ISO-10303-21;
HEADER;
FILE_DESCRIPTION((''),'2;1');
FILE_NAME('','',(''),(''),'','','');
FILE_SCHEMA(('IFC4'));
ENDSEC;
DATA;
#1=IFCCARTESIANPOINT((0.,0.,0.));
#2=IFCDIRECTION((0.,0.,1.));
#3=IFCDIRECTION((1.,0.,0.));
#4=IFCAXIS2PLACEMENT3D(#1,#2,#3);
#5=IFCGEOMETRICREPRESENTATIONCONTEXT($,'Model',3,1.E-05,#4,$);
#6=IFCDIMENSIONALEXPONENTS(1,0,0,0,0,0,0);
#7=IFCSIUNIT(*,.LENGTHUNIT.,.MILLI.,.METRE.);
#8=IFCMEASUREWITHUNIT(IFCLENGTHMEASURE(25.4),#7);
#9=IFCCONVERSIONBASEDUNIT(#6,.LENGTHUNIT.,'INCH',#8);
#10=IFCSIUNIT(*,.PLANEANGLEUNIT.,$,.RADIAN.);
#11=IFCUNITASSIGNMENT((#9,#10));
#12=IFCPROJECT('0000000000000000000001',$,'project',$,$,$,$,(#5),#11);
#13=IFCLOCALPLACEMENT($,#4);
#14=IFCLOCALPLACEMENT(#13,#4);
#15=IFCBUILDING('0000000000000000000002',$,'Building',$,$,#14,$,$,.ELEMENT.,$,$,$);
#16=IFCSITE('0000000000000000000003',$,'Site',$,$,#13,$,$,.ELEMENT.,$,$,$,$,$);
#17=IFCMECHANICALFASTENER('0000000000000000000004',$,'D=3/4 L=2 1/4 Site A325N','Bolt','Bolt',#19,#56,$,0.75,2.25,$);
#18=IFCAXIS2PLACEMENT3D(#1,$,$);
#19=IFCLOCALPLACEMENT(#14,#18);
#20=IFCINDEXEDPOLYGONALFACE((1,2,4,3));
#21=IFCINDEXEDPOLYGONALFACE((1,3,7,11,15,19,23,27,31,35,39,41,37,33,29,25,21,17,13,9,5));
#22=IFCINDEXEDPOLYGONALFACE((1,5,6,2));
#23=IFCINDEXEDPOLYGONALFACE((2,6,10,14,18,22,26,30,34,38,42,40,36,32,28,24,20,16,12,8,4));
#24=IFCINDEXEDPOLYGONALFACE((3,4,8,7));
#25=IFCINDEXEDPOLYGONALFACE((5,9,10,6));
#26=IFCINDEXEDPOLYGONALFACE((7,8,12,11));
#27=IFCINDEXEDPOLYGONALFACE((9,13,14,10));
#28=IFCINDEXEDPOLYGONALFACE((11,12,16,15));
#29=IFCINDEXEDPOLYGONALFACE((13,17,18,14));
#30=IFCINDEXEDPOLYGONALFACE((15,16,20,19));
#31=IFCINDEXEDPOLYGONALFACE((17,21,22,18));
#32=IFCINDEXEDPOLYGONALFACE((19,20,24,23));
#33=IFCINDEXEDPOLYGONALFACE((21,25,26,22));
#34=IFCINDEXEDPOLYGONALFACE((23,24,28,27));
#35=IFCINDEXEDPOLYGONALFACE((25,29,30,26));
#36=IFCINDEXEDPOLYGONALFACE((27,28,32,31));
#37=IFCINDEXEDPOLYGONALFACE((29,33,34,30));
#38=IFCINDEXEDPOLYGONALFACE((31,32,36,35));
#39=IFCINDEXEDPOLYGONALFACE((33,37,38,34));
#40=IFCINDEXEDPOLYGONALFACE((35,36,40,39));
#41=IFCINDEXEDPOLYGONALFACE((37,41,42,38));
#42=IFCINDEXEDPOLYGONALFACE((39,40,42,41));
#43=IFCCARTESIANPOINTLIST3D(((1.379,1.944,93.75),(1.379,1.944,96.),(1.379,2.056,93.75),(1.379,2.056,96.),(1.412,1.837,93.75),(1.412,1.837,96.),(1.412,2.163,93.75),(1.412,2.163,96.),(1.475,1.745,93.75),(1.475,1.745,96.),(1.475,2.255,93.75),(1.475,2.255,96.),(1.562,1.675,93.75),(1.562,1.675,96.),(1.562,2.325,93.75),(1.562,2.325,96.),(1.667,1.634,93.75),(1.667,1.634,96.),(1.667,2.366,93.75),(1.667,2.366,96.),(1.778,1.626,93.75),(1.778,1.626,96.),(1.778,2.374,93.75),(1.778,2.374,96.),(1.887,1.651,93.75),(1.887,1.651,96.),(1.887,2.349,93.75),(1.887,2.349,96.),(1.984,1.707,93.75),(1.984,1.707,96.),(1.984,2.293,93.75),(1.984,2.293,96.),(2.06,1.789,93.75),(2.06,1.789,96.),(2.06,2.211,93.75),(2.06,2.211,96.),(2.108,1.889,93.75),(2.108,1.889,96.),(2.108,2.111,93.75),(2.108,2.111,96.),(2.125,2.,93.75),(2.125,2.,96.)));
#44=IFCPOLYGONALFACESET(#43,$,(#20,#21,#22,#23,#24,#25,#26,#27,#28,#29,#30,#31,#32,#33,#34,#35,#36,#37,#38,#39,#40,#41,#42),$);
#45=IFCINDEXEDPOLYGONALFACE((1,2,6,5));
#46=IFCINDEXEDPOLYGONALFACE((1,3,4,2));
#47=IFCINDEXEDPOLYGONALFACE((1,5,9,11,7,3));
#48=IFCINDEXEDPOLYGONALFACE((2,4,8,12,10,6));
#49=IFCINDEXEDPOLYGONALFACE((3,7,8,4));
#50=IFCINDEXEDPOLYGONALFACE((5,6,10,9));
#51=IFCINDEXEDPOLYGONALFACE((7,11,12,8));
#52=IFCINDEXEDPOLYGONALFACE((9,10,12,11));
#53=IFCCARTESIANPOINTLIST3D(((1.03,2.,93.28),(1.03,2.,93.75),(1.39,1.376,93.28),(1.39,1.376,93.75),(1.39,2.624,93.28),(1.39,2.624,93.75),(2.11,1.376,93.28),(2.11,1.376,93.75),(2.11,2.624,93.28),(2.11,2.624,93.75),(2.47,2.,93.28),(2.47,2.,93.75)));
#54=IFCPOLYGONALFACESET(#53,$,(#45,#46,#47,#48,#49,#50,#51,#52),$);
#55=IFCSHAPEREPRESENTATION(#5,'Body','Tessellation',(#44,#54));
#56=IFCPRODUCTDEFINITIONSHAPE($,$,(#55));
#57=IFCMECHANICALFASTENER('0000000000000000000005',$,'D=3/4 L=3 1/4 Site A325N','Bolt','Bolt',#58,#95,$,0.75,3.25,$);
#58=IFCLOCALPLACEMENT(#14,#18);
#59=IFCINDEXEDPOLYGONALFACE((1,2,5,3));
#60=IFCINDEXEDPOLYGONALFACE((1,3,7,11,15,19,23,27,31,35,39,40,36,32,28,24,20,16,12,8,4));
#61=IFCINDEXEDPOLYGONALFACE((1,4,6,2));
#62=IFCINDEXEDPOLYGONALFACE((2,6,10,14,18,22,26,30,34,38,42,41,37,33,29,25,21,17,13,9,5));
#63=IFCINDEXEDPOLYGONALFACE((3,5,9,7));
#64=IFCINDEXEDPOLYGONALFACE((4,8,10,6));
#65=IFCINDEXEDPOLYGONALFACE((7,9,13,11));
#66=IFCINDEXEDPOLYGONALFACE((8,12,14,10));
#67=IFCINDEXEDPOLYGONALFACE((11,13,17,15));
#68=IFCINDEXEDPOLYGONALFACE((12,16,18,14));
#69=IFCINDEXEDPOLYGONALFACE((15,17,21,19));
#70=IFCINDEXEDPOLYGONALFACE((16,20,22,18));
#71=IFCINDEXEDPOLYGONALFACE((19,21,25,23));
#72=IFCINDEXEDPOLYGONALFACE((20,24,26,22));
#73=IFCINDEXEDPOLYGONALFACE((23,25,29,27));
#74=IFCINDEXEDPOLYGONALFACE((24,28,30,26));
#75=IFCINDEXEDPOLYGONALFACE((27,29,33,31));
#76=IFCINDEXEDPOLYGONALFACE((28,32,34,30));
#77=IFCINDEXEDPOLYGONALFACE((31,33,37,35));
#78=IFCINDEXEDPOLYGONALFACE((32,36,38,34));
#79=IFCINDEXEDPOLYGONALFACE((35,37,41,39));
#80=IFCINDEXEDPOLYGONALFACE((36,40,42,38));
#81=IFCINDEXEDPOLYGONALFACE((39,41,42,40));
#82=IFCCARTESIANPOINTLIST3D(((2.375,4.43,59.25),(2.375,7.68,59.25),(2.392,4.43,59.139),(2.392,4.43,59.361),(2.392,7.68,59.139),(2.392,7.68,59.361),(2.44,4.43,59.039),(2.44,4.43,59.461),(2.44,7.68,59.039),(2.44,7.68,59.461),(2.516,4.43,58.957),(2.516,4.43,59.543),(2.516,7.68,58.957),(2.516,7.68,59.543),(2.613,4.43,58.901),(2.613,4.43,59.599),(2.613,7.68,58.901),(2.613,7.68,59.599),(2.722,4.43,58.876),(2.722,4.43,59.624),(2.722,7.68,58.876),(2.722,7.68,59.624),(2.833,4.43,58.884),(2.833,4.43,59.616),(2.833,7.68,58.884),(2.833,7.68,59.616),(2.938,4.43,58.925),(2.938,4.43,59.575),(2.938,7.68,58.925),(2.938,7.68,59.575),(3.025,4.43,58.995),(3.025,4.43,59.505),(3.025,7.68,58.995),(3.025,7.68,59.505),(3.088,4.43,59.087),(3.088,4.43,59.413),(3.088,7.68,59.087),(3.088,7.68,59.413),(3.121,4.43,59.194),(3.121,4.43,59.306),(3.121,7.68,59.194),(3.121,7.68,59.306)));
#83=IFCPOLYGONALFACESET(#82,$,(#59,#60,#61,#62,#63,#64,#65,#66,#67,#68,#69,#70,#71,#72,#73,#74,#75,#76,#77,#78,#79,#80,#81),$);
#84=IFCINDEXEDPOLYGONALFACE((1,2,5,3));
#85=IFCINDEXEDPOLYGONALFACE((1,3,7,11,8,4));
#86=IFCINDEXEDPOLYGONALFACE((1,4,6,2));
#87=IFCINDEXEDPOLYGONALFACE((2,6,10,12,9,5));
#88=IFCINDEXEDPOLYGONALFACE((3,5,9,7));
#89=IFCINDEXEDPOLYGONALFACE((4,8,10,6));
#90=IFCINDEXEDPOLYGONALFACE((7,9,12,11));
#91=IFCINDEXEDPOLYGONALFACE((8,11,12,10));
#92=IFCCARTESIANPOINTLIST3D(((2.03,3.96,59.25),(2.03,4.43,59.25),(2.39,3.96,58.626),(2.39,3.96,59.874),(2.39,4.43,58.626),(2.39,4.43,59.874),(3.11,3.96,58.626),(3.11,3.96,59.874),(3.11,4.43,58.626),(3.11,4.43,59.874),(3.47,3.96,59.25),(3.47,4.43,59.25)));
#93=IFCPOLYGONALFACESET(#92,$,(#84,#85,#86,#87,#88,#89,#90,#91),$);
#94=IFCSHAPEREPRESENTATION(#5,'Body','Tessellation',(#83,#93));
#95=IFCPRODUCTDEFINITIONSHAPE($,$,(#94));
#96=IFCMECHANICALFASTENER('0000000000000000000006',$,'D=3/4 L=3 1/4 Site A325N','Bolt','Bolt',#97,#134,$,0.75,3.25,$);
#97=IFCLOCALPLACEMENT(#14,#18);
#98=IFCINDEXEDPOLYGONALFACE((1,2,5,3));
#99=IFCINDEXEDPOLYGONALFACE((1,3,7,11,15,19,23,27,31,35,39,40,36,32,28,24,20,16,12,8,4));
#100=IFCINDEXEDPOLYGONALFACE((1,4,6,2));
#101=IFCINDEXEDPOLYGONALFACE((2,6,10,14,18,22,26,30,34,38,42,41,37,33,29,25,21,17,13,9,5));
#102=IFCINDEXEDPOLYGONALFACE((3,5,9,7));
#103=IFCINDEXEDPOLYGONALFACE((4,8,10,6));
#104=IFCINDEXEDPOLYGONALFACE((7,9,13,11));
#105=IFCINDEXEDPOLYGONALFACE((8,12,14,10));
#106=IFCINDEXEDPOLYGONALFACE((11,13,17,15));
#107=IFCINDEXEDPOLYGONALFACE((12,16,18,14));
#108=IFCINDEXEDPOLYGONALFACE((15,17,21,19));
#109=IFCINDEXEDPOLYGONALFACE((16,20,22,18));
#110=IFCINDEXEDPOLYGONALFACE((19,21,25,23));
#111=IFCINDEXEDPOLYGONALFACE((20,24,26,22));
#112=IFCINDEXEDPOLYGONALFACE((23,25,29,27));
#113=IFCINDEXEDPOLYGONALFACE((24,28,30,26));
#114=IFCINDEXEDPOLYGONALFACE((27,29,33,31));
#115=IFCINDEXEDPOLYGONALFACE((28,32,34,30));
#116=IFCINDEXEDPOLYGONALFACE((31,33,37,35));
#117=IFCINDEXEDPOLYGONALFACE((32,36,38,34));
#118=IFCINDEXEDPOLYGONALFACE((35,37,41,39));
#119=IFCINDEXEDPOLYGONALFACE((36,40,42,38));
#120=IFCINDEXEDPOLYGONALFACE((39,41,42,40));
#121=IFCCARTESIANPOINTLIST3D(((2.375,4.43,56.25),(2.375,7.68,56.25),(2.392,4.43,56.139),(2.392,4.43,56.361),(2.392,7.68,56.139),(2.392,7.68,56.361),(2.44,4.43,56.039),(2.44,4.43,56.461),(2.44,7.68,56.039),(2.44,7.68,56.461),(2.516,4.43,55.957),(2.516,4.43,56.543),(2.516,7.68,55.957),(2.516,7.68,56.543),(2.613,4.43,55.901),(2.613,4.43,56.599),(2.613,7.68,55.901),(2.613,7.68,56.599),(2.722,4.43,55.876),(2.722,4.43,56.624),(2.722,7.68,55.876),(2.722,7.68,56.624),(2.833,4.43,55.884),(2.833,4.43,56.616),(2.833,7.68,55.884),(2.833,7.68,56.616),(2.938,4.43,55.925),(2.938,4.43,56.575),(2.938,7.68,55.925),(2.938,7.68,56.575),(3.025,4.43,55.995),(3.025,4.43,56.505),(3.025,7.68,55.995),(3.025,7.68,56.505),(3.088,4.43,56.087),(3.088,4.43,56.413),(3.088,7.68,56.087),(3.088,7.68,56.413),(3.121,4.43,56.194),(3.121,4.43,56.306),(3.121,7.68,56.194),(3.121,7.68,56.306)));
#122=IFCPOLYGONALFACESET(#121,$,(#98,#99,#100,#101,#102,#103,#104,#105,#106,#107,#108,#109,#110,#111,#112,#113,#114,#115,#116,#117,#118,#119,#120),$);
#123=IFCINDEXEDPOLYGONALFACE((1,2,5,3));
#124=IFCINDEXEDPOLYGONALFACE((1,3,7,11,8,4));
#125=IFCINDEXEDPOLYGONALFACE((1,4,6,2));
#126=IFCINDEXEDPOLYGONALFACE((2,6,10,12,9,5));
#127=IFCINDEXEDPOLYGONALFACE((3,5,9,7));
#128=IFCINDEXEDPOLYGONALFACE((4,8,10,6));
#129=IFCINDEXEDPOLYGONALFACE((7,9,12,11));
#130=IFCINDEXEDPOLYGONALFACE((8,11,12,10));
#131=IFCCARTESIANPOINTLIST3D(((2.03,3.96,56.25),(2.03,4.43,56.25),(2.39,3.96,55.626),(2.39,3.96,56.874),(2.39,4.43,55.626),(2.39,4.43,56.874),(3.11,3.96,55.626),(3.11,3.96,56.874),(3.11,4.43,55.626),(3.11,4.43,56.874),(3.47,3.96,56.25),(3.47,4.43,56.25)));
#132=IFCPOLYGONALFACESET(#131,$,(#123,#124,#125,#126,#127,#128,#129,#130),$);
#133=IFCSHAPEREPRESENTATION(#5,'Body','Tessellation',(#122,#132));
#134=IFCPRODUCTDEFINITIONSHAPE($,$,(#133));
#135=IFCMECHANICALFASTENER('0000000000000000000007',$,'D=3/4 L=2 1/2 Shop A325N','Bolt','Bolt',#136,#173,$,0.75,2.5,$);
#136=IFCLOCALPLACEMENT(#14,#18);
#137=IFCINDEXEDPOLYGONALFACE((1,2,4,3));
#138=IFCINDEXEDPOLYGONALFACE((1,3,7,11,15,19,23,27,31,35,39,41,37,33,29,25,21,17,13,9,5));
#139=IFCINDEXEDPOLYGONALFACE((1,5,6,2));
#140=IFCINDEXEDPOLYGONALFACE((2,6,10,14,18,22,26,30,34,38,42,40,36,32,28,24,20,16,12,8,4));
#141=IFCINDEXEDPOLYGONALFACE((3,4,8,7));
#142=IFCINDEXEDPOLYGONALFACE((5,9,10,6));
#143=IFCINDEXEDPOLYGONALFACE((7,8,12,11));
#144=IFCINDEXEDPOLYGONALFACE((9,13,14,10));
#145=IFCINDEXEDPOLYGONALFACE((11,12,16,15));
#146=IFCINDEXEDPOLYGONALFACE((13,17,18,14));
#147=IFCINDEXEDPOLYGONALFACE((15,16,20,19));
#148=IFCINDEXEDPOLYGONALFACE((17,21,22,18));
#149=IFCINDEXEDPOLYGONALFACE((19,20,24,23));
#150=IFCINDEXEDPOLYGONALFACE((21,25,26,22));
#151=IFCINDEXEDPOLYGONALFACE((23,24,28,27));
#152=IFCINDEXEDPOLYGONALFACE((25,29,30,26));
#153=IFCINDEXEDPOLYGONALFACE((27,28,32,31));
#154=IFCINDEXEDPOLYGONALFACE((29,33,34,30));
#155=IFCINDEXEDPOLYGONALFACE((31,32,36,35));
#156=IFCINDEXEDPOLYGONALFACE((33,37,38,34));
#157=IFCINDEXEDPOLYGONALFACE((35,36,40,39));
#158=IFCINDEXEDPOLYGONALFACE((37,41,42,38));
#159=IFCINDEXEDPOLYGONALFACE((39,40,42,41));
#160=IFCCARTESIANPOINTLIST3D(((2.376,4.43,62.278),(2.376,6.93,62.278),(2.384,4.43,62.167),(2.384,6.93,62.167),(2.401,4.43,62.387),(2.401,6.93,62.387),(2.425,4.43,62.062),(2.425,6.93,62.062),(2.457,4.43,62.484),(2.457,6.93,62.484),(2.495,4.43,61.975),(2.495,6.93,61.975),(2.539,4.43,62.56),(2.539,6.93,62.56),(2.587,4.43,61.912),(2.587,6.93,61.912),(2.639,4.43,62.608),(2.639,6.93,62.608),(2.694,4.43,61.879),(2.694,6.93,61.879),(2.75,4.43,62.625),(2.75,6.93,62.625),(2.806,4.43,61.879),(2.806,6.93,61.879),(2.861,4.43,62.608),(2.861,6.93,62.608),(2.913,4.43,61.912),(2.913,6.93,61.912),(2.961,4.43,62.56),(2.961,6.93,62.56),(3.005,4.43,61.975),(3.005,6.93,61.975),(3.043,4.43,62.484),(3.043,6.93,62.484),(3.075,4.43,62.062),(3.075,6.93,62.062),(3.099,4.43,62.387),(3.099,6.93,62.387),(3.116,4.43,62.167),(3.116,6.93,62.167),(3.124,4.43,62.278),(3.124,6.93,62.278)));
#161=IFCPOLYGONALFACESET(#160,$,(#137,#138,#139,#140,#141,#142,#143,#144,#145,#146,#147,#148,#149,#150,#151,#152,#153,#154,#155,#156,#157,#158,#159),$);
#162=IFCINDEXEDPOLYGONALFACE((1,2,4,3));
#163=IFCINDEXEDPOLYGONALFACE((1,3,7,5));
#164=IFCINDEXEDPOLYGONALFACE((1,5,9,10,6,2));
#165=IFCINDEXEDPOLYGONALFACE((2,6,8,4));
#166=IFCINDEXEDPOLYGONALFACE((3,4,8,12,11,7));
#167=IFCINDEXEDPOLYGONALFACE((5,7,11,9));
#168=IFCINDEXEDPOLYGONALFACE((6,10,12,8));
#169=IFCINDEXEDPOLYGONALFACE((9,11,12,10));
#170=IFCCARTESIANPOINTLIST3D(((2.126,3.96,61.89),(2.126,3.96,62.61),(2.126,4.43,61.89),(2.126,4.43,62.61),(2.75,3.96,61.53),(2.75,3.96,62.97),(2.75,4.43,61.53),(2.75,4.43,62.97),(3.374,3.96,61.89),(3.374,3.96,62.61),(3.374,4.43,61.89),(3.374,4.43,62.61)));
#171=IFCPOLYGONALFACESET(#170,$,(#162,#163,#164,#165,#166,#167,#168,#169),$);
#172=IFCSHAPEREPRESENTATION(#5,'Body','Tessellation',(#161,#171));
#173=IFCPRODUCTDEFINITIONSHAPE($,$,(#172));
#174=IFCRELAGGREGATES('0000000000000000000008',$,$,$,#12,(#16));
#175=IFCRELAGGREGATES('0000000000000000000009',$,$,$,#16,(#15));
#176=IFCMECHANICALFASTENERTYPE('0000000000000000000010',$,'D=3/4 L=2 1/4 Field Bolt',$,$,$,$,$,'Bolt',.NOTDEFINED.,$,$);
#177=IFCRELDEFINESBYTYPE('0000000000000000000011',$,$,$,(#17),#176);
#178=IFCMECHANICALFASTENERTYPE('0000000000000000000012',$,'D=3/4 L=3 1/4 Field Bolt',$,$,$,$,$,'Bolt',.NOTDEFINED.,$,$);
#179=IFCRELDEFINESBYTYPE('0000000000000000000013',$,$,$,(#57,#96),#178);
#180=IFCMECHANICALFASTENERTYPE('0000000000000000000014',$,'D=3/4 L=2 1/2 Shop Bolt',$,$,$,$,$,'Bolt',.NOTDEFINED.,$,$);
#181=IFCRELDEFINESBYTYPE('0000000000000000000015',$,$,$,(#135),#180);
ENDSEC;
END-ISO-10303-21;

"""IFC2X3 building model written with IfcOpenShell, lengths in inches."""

from ifc_helpers import new_model, entity, si_unit, converted_unit, frame, origin_with_axes, origin_2d_with_axis, place, context, project, spatial, polyline, circle, outline, extrude, source, transform, mapped, type_object, type_shapes, element, save


model = new_model("IFC2X3")

# Units and contexts
model_context = context("Model", 3, precision=1e-05, world=origin_with_axes())
ifc_project = project(units=[converted_unit("LENGTHUNIT", "INCH", entity("IfcLengthMeasure", 25.4), si_unit("LENGTHUNIT", "METRE", prefix="MILLI"), dimensions=[1, 0, 0, 0, 0, 0, 0]), si_unit("PLANEANGLEUNIT", "RADIAN")], contexts=[model_context])

# Site, building
site_placement = place(None, origin_with_axes())
site = spatial("IfcSite", under=ifc_project, at=site_placement, Name="Site", CompositionType="ELEMENT")
building_placement = place(site_placement, origin_with_axes())
building = spatial("IfcBuilding", under=site, at=building_placement, Name="Building", CompositionType="ELEMENT")

# Mechanical fasteners
mechanical_fastener_type_1 = type_object("IfcMechanicalFastenerType", Name="D=3/4 L=2 1/4 Field Bolt", ElementType="Bolt")
shared_shape_1 = source(origin_with_axes(), model_context, "Body", "SweptSolid", [
    extrude(circle(Radius=0.375, at=origin_2d_with_axis()), frame((0.0, 0.0, 0.0), z_axis=(1.0, 0.0, 0.0), x_axis=(0.0, 1.0, 0.0)), (0.0, 0.0, 1.0), 2.25),
    extrude(outline(polyline([(-0.72, 0.0), (-0.36, 0.624), (0.36, 0.624), (0.72, 0.0), (0.36, -0.624), (-0.36, -0.624), (-0.72, 0.0)])), frame((0.0, 0.0, 0.0), z_axis=(1.0, 0.0, 0.0), x_axis=(0.0, 1.0, 0.0)), (0.0, 0.0, -1.0), 0.47),
])
type_shapes(mechanical_fastener_type_1, [shared_shape_1])
placement_1 = place(building_placement, frame((0.0, 0.0, 54.5), z_axis=(0.0, -1.0, 0.0), x_axis=(0.0, 0.0, 1.0)))
placement_2 = place(placement_1, frame((39.25, -1.75, -2.0), z_axis=(0.0, 0.0, -1.0), x_axis=(1.0, 0.0, 0.0)))
mechanical_fastener_1_placement = place(placement_2, origin_with_axes())
element("IfcMechanicalFastener", 1, at=mechanical_fastener_1_placement, type_object=mechanical_fastener_type_1, Name="D=3/4 L=2 1/4 Site A325N", Description="Bolt", ObjectType="Bolt", NominalDiameter=0.75, NominalLength=2.25, context=model_context, shape_type="MappedRepresentation", body=[
    mapped(shared_shape_1, transform((0.0, 0.0, 0.0), scale=1.0)),
])
mechanical_fastener_type_2 = type_object("IfcMechanicalFastenerType", Name="D=3/4 L=3 1/4 Field Bolt", ElementType="Bolt")
shared_shape_2 = source(origin_with_axes(), model_context, "Body", "SweptSolid", [
    extrude(circle(Radius=0.375, at=origin_2d_with_axis()), frame((0.0, 0.0, 0.0), z_axis=(1.0, 0.0, 0.0), x_axis=(0.0, 1.0, 0.0)), (0.0, 0.0, 1.0), 3.25),
    extrude(outline(polyline([(-0.72, 0.0), (-0.36, 0.624), (0.36, 0.624), (0.72, 0.0), (0.36, -0.624), (-0.36, -0.624), (-0.72, 0.0)])), frame((0.0, 0.0, 0.0), z_axis=(1.0, 0.0, 0.0), x_axis=(0.0, 1.0, 0.0)), (0.0, 0.0, -1.0), 0.47),
])
type_shapes(mechanical_fastener_type_2, [shared_shape_2])
placement_3 = place(placement_1, frame((1.75, 2.75, -4.43), z_axis=(1.0, 0.0, 0.0), x_axis=(0.0, 0.0, -1.0)))
for number, where, z_axis, x_axis, name in (
    (2, (0.0, -5.5, 3.0), (0.0, 0.0, 1.0), (1.0, 0.0, 0.0), "D=3/4 L=3 1/4 Site A325N"),
    (3, (0.0, -5.5, 0.0), (0.0, 0.0, 1.0), (1.0, 0.0, 0.0), "D=3/4 L=3 1/4 Site A325N"),
):
    element("IfcMechanicalFastener", number, at=place(placement_3, frame(where, z_axis=z_axis, x_axis=x_axis)), type_object=mechanical_fastener_type_2, Name=name, Description="Bolt", ObjectType="Bolt", NominalDiameter=0.75, NominalLength=3.25, context=model_context, shape_type="MappedRepresentation", body=[
        mapped(shared_shape_2, transform((0.0, 0.0, 0.0), scale=1.0)),
    ])
mechanical_fastener_type_3 = type_object("IfcMechanicalFastenerType", Name="D=3/4 L=2 1/2 Shop Bolt", ElementType="Bolt")
shared_shape_3 = source(origin_with_axes(), model_context, "Body", "SweptSolid", [
    extrude(circle(Radius=0.375, at=origin_2d_with_axis()), frame((0.0, 0.0, 0.0), z_axis=(1.0, 0.0, 0.0), x_axis=(0.0, 1.0, 0.0)), (0.0, 0.0, 1.0), 2.5),
    extrude(outline(polyline([(-0.72, 0.0), (-0.36, 0.624), (0.36, 0.624), (0.72, 0.0), (0.36, -0.624), (-0.36, -0.624), (-0.72, 0.0)])), frame((0.0, 0.0, 0.0), z_axis=(1.0, 0.0, 0.0), x_axis=(0.0, 1.0, 0.0)), (0.0, 0.0, -1.0), 0.47),
])
type_shapes(mechanical_fastener_type_3, [shared_shape_3])
placement_4 = place(placement_1, frame((7.75, 2.75, -4.43), z_axis=(0.0, -1.0, 0.0), x_axis=(0.0, 0.0, -1.0)))
mechanical_fastener_2_placement = place(placement_4, frame((0.0, 0.0, 5.5), z_axis=(0.0, 0.0, 1.0), x_axis=(1.0, 0.0, 0.0)))
element("IfcMechanicalFastener", 4, at=mechanical_fastener_2_placement, type_object=mechanical_fastener_type_3, Name="D=3/4 L=2 1/2 Shop A325N", Description="Bolt", ObjectType="Bolt", NominalDiameter=0.75, NominalLength=2.5, context=model_context, shape_type="MappedRepresentation", body=[
    mapped(shared_shape_3, transform((0.0, 0.0, 0.0), scale=1.0)),
])

save(model, "model.ifc")
